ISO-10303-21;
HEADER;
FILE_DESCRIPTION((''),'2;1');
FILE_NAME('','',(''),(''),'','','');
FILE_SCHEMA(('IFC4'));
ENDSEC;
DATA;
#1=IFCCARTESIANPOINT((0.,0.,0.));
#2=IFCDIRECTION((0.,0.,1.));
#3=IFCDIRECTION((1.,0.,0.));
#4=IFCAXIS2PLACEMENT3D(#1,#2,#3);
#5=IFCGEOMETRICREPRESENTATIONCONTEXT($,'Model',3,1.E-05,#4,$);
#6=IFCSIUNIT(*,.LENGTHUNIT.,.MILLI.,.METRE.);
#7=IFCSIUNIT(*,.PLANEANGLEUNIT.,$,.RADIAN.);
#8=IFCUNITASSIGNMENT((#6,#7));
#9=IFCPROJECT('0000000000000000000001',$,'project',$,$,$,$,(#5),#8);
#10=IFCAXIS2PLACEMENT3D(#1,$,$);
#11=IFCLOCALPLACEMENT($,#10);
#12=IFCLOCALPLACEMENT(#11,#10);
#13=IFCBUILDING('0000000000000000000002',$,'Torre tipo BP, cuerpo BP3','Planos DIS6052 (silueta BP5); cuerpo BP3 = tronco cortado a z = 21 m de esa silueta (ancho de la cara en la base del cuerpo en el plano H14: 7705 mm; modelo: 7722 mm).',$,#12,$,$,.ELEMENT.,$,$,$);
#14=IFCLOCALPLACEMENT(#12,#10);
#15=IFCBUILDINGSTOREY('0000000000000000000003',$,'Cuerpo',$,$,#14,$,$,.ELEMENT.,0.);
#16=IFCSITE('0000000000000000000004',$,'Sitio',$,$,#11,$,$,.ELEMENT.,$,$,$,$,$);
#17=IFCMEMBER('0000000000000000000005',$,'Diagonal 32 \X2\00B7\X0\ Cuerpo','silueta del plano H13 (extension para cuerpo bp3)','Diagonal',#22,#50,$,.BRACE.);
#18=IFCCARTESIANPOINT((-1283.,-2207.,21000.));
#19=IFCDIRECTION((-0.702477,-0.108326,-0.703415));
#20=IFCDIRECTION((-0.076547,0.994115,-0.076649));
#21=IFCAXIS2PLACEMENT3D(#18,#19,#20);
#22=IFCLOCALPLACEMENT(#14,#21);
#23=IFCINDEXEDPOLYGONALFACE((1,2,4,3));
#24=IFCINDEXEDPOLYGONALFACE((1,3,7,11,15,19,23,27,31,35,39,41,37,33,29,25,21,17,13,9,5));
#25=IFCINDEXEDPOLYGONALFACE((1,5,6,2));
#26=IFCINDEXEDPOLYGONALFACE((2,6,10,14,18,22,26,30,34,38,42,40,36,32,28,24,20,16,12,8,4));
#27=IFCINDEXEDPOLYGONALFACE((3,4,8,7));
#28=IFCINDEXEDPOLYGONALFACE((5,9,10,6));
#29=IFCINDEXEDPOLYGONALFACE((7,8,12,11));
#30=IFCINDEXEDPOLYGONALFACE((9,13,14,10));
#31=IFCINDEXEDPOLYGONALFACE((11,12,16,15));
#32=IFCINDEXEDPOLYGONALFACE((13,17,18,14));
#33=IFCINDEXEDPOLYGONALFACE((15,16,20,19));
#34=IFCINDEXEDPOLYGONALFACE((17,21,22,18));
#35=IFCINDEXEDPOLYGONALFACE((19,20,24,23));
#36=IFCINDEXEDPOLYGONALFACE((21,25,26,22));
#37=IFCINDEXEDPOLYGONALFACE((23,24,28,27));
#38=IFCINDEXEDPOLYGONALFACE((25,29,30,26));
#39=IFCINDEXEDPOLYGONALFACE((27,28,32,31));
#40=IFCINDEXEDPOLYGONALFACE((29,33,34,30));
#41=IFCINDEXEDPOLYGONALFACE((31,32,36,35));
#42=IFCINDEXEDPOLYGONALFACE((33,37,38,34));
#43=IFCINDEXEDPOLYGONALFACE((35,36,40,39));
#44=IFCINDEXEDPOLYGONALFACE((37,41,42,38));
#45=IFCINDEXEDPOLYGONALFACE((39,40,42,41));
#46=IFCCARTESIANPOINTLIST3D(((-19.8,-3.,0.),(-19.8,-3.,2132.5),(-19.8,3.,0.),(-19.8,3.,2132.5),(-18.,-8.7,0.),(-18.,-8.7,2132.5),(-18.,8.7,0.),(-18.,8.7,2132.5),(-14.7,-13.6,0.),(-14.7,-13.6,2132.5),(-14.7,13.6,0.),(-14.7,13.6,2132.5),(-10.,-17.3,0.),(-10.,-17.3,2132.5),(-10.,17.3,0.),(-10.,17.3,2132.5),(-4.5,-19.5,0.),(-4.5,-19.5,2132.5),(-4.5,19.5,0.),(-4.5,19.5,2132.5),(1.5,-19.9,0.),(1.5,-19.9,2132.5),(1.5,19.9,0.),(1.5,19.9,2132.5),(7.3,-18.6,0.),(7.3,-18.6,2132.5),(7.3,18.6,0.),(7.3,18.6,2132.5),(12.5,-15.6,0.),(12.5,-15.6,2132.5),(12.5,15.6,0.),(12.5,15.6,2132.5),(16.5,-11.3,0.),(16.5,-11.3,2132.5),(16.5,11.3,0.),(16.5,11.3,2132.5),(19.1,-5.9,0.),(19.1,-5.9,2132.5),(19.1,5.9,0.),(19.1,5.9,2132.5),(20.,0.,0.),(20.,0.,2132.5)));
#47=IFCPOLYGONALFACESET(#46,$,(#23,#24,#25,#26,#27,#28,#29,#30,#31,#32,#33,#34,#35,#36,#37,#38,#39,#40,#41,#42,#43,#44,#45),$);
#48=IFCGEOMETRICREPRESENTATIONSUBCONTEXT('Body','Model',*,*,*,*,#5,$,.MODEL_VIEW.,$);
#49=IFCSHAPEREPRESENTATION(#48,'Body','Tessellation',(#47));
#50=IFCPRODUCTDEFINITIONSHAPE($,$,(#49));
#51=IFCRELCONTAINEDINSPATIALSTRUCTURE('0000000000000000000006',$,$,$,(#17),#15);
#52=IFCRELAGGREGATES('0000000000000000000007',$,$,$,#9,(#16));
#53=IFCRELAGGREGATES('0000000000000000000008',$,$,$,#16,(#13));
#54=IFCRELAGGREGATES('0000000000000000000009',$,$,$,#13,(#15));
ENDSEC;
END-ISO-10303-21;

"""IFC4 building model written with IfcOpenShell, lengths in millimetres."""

from ifc_helpers import new_model, si_unit, frame, origin, origin_with_axes, place, context, subcontext, project, spatial, circle, extrude, element, save


model = new_model("IFC4")

# Units and contexts
model_context = context("Model", 3, precision=1e-05, world=origin_with_axes())
body_context = subcontext(model_context, "Body", "Model", "MODEL_VIEW")
ifc_project = project(units=[si_unit("LENGTHUNIT", "METRE", prefix="MILLI"), si_unit("PLANEANGLEUNIT", "RADIAN")], contexts=[model_context])

# Site, building, storey
site_placement = place(None, origin())
site = spatial("IfcSite", under=ifc_project, at=site_placement, Name="Sitio", CompositionType="ELEMENT")
building_placement = place(site_placement, origin())
building = spatial("IfcBuilding", under=site, at=building_placement, Name="Torre tipo BP, cuerpo BP3", Description="Planos DIS6052 (silueta BP5); cuerpo BP3 = tronco cortado a z = 21 m de esa silueta (ancho de la cara en la base del cuerpo en el plano H14: 7705 mm; modelo: 7722 mm).", CompositionType="ELEMENT")
storey_placement = place(building_placement, origin())
storey = spatial("IfcBuildingStorey", under=building, at=storey_placement, Name="Cuerpo", CompositionType="ELEMENT", Elevation=0.0)

# Member
member_1_placement = place(storey_placement, frame((-1283.0, -2207.0, 21000.0), z_axis=(-0.702477, -0.108326, -0.703415), x_axis=(-0.076547, 0.994115, -0.076649)))
element("IfcMember", 1, at=member_1_placement, inside=storey, Name="Diagonal 32 · Cuerpo", Description="silueta del plano H13 (extension para cuerpo bp3)", ObjectType="Diagonal", PredefinedType="BRACE", context=body_context, shape_type="SweptSolid", body=[
    extrude(circle(Radius=20.0), None, (0.0, 0.0, 1.0), 2132.5),
])

save(model, "model.ifc")
